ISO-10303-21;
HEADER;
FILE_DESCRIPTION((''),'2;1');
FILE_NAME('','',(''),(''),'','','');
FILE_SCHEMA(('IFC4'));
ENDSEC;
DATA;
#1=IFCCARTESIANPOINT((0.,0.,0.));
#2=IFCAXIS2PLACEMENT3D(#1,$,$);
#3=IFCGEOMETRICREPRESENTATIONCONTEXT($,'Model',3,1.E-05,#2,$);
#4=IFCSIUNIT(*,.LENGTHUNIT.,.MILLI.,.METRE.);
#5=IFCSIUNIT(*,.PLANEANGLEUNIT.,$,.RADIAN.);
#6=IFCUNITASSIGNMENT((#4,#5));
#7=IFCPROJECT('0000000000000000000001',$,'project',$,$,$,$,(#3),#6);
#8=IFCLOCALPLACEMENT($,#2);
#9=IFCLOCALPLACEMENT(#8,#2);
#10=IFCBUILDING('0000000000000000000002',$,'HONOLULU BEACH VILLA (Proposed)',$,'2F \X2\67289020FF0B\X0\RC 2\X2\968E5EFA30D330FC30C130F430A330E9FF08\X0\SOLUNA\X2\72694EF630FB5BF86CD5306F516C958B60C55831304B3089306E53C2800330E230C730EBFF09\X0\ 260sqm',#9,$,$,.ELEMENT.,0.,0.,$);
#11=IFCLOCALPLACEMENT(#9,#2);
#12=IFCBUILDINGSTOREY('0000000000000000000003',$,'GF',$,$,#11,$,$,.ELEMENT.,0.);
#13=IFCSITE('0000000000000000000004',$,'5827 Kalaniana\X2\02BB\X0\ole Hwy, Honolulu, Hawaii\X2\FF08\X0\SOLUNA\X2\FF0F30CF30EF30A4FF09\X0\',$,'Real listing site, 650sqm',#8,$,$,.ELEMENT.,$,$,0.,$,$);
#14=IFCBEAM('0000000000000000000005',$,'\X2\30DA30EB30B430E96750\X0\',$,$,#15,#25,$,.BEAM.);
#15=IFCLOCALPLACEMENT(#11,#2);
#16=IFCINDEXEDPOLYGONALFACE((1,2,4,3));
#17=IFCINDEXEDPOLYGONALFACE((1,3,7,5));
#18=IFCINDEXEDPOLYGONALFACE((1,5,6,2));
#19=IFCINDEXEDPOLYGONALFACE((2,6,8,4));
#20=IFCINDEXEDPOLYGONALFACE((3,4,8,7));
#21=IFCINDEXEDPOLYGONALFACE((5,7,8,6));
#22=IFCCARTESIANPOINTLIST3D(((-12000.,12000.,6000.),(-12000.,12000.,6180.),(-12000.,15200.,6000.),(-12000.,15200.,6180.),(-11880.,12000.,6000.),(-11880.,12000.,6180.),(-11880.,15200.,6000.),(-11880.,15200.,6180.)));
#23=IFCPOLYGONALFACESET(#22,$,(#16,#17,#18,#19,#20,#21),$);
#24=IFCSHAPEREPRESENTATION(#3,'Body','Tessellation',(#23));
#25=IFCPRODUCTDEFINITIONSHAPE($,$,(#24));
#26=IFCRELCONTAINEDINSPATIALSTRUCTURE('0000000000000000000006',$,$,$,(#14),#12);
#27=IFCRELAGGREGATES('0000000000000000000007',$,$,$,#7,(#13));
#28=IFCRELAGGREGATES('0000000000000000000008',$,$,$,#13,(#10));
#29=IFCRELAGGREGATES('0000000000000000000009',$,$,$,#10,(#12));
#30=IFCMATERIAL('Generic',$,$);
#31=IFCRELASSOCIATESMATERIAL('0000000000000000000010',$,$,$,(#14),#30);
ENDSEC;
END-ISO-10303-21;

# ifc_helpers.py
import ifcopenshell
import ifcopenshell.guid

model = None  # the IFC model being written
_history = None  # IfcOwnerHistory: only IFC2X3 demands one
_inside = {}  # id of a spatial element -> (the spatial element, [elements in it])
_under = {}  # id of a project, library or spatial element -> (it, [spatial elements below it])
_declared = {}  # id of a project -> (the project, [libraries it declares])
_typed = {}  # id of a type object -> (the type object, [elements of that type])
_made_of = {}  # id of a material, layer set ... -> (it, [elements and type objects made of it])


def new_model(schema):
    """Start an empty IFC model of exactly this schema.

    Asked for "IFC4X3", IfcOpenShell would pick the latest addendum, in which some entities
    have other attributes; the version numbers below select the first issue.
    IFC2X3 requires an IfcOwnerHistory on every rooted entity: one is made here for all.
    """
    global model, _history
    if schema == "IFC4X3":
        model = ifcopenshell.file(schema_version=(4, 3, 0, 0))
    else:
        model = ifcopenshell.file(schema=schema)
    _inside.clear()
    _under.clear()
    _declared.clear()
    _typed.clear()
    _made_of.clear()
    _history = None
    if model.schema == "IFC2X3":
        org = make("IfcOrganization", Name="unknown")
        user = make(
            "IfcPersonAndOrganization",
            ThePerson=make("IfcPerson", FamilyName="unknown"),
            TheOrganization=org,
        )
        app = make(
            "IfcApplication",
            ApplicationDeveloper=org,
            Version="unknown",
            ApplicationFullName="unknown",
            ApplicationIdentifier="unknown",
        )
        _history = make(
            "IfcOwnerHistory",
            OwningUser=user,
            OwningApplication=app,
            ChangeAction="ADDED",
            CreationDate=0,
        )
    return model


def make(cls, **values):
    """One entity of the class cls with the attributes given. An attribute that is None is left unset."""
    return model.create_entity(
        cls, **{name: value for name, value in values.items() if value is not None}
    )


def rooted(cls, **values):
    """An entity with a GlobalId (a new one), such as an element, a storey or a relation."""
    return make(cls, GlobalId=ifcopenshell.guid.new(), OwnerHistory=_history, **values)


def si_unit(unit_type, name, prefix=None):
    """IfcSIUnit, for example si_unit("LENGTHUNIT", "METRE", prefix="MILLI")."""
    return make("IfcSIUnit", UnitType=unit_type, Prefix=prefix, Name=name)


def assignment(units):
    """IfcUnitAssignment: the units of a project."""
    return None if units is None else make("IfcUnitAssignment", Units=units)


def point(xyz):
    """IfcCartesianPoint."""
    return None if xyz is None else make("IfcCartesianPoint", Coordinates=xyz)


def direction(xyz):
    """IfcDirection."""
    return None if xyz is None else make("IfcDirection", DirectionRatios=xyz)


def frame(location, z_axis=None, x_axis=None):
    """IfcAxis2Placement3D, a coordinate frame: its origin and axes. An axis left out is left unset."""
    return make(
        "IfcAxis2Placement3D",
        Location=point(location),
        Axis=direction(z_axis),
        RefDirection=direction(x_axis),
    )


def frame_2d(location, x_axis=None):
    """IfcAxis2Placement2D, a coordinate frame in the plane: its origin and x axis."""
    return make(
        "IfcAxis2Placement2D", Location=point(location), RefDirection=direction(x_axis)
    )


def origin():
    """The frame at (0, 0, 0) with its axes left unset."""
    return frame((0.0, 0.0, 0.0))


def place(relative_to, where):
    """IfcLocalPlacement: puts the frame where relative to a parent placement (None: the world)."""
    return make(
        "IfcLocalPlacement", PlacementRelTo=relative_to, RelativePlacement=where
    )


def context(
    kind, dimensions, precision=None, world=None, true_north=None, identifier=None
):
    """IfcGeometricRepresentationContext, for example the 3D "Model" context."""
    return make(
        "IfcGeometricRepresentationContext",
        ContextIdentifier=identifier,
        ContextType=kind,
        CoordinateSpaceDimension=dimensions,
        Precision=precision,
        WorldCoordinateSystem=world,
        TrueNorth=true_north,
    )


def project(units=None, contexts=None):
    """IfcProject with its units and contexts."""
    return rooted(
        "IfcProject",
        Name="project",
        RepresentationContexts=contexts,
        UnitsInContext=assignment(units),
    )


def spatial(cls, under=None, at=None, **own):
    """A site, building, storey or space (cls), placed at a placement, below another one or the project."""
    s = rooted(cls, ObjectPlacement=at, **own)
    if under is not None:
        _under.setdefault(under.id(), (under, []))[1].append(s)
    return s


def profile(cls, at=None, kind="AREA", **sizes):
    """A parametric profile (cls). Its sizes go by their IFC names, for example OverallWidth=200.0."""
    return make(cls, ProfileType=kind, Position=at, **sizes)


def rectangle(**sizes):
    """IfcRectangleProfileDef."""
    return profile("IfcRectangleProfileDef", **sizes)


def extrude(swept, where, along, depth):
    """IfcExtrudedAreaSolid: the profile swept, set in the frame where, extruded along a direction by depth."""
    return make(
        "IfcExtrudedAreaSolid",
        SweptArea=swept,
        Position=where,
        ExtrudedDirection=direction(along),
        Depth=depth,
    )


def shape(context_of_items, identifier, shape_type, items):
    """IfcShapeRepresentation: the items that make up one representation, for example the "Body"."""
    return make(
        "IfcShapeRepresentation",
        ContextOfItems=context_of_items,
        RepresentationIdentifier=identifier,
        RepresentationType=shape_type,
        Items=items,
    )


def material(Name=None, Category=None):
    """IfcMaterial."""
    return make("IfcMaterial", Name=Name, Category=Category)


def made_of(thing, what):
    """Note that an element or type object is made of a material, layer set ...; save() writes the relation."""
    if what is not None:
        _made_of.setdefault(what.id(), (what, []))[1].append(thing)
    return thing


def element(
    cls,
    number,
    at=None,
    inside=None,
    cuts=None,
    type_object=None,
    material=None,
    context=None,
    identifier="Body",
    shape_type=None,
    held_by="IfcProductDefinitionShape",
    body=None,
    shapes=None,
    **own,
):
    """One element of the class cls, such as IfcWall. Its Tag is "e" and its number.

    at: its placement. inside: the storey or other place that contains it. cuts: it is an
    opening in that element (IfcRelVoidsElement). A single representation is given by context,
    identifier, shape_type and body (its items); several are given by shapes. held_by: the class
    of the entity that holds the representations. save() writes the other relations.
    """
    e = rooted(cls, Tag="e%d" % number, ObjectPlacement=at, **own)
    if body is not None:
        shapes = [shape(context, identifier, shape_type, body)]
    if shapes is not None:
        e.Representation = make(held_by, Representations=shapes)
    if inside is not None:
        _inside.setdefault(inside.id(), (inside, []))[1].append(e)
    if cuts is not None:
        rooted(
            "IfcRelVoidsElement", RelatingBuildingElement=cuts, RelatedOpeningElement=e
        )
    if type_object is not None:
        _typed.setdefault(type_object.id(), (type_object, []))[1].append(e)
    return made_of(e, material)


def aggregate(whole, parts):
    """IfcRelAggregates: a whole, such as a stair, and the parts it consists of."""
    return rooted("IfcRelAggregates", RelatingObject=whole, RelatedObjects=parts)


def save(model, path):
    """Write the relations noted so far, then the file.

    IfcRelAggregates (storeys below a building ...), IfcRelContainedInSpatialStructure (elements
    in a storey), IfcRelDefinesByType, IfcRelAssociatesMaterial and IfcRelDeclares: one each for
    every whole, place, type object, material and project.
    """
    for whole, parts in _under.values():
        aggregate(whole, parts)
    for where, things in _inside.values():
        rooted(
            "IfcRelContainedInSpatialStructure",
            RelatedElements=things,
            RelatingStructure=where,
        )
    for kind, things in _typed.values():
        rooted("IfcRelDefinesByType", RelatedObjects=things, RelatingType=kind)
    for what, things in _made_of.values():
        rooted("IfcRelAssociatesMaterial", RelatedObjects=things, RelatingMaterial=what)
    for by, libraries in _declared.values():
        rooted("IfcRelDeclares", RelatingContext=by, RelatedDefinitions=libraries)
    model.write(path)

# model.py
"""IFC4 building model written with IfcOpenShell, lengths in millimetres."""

from ifc_helpers import new_model, si_unit, frame, frame_2d, origin, place, context, project, spatial, rectangle, extrude, material, element, save


model = new_model("IFC4")

# Units and contexts
model_context = context("Model", 3, precision=1e-05, world=origin())
ifc_project = project(units=[si_unit("LENGTHUNIT", "METRE", prefix="MILLI"), si_unit("PLANEANGLEUNIT", "RADIAN")], contexts=[model_context])

# Site, building, storey
site_placement = place(None, origin())
site = spatial("IfcSite", under=ifc_project, at=site_placement, Name="5827 Kalanianaʻole Hwy, Honolulu, Hawaii（SOLUNA／ハワイ）", ObjectType="Real listing site, 650sqm", CompositionType="ELEMENT", RefElevation=0.0)
building_placement = place(site_placement, origin())
building = spatial("IfcBuilding", under=site, at=building_placement, Name="HONOLULU BEACH VILLA (Proposed)", ObjectType="2F 木造＋RC 2階建ビーチヴィラ（SOLUNA物件・寸法は公開情報からの参考モデル） 260sqm", CompositionType="ELEMENT", ElevationOfRefHeight=0.0, ElevationOfTerrain=0.0)
storey_placement = place(building_placement, origin())
storey = spatial("IfcBuildingStorey", under=building, at=storey_placement, Name="GF", CompositionType="ELEMENT", Elevation=0.0)

# Shared definitions
ifc_material_1 = material(Name="Generic")

# Beam
beam_1_placement = place(storey_placement, frame((-6000.0, 6000.0, 3000.0)))
element("IfcBeam", 1, at=beam_1_placement, inside=storey, material=ifc_material_1, Name="ペルゴラ材", PredefinedType="BEAM", context=model_context, shape_type="SweptSolid", body=[
    extrude(rectangle(XDim=120.0, YDim=3200.0, at=frame_2d((60.0, 1600.0))), frame((-6000.0, 6000.0, 3000.0)), (0.0, 0.0, 1.0), 180.0),
])

save(model, "model.ifc")
